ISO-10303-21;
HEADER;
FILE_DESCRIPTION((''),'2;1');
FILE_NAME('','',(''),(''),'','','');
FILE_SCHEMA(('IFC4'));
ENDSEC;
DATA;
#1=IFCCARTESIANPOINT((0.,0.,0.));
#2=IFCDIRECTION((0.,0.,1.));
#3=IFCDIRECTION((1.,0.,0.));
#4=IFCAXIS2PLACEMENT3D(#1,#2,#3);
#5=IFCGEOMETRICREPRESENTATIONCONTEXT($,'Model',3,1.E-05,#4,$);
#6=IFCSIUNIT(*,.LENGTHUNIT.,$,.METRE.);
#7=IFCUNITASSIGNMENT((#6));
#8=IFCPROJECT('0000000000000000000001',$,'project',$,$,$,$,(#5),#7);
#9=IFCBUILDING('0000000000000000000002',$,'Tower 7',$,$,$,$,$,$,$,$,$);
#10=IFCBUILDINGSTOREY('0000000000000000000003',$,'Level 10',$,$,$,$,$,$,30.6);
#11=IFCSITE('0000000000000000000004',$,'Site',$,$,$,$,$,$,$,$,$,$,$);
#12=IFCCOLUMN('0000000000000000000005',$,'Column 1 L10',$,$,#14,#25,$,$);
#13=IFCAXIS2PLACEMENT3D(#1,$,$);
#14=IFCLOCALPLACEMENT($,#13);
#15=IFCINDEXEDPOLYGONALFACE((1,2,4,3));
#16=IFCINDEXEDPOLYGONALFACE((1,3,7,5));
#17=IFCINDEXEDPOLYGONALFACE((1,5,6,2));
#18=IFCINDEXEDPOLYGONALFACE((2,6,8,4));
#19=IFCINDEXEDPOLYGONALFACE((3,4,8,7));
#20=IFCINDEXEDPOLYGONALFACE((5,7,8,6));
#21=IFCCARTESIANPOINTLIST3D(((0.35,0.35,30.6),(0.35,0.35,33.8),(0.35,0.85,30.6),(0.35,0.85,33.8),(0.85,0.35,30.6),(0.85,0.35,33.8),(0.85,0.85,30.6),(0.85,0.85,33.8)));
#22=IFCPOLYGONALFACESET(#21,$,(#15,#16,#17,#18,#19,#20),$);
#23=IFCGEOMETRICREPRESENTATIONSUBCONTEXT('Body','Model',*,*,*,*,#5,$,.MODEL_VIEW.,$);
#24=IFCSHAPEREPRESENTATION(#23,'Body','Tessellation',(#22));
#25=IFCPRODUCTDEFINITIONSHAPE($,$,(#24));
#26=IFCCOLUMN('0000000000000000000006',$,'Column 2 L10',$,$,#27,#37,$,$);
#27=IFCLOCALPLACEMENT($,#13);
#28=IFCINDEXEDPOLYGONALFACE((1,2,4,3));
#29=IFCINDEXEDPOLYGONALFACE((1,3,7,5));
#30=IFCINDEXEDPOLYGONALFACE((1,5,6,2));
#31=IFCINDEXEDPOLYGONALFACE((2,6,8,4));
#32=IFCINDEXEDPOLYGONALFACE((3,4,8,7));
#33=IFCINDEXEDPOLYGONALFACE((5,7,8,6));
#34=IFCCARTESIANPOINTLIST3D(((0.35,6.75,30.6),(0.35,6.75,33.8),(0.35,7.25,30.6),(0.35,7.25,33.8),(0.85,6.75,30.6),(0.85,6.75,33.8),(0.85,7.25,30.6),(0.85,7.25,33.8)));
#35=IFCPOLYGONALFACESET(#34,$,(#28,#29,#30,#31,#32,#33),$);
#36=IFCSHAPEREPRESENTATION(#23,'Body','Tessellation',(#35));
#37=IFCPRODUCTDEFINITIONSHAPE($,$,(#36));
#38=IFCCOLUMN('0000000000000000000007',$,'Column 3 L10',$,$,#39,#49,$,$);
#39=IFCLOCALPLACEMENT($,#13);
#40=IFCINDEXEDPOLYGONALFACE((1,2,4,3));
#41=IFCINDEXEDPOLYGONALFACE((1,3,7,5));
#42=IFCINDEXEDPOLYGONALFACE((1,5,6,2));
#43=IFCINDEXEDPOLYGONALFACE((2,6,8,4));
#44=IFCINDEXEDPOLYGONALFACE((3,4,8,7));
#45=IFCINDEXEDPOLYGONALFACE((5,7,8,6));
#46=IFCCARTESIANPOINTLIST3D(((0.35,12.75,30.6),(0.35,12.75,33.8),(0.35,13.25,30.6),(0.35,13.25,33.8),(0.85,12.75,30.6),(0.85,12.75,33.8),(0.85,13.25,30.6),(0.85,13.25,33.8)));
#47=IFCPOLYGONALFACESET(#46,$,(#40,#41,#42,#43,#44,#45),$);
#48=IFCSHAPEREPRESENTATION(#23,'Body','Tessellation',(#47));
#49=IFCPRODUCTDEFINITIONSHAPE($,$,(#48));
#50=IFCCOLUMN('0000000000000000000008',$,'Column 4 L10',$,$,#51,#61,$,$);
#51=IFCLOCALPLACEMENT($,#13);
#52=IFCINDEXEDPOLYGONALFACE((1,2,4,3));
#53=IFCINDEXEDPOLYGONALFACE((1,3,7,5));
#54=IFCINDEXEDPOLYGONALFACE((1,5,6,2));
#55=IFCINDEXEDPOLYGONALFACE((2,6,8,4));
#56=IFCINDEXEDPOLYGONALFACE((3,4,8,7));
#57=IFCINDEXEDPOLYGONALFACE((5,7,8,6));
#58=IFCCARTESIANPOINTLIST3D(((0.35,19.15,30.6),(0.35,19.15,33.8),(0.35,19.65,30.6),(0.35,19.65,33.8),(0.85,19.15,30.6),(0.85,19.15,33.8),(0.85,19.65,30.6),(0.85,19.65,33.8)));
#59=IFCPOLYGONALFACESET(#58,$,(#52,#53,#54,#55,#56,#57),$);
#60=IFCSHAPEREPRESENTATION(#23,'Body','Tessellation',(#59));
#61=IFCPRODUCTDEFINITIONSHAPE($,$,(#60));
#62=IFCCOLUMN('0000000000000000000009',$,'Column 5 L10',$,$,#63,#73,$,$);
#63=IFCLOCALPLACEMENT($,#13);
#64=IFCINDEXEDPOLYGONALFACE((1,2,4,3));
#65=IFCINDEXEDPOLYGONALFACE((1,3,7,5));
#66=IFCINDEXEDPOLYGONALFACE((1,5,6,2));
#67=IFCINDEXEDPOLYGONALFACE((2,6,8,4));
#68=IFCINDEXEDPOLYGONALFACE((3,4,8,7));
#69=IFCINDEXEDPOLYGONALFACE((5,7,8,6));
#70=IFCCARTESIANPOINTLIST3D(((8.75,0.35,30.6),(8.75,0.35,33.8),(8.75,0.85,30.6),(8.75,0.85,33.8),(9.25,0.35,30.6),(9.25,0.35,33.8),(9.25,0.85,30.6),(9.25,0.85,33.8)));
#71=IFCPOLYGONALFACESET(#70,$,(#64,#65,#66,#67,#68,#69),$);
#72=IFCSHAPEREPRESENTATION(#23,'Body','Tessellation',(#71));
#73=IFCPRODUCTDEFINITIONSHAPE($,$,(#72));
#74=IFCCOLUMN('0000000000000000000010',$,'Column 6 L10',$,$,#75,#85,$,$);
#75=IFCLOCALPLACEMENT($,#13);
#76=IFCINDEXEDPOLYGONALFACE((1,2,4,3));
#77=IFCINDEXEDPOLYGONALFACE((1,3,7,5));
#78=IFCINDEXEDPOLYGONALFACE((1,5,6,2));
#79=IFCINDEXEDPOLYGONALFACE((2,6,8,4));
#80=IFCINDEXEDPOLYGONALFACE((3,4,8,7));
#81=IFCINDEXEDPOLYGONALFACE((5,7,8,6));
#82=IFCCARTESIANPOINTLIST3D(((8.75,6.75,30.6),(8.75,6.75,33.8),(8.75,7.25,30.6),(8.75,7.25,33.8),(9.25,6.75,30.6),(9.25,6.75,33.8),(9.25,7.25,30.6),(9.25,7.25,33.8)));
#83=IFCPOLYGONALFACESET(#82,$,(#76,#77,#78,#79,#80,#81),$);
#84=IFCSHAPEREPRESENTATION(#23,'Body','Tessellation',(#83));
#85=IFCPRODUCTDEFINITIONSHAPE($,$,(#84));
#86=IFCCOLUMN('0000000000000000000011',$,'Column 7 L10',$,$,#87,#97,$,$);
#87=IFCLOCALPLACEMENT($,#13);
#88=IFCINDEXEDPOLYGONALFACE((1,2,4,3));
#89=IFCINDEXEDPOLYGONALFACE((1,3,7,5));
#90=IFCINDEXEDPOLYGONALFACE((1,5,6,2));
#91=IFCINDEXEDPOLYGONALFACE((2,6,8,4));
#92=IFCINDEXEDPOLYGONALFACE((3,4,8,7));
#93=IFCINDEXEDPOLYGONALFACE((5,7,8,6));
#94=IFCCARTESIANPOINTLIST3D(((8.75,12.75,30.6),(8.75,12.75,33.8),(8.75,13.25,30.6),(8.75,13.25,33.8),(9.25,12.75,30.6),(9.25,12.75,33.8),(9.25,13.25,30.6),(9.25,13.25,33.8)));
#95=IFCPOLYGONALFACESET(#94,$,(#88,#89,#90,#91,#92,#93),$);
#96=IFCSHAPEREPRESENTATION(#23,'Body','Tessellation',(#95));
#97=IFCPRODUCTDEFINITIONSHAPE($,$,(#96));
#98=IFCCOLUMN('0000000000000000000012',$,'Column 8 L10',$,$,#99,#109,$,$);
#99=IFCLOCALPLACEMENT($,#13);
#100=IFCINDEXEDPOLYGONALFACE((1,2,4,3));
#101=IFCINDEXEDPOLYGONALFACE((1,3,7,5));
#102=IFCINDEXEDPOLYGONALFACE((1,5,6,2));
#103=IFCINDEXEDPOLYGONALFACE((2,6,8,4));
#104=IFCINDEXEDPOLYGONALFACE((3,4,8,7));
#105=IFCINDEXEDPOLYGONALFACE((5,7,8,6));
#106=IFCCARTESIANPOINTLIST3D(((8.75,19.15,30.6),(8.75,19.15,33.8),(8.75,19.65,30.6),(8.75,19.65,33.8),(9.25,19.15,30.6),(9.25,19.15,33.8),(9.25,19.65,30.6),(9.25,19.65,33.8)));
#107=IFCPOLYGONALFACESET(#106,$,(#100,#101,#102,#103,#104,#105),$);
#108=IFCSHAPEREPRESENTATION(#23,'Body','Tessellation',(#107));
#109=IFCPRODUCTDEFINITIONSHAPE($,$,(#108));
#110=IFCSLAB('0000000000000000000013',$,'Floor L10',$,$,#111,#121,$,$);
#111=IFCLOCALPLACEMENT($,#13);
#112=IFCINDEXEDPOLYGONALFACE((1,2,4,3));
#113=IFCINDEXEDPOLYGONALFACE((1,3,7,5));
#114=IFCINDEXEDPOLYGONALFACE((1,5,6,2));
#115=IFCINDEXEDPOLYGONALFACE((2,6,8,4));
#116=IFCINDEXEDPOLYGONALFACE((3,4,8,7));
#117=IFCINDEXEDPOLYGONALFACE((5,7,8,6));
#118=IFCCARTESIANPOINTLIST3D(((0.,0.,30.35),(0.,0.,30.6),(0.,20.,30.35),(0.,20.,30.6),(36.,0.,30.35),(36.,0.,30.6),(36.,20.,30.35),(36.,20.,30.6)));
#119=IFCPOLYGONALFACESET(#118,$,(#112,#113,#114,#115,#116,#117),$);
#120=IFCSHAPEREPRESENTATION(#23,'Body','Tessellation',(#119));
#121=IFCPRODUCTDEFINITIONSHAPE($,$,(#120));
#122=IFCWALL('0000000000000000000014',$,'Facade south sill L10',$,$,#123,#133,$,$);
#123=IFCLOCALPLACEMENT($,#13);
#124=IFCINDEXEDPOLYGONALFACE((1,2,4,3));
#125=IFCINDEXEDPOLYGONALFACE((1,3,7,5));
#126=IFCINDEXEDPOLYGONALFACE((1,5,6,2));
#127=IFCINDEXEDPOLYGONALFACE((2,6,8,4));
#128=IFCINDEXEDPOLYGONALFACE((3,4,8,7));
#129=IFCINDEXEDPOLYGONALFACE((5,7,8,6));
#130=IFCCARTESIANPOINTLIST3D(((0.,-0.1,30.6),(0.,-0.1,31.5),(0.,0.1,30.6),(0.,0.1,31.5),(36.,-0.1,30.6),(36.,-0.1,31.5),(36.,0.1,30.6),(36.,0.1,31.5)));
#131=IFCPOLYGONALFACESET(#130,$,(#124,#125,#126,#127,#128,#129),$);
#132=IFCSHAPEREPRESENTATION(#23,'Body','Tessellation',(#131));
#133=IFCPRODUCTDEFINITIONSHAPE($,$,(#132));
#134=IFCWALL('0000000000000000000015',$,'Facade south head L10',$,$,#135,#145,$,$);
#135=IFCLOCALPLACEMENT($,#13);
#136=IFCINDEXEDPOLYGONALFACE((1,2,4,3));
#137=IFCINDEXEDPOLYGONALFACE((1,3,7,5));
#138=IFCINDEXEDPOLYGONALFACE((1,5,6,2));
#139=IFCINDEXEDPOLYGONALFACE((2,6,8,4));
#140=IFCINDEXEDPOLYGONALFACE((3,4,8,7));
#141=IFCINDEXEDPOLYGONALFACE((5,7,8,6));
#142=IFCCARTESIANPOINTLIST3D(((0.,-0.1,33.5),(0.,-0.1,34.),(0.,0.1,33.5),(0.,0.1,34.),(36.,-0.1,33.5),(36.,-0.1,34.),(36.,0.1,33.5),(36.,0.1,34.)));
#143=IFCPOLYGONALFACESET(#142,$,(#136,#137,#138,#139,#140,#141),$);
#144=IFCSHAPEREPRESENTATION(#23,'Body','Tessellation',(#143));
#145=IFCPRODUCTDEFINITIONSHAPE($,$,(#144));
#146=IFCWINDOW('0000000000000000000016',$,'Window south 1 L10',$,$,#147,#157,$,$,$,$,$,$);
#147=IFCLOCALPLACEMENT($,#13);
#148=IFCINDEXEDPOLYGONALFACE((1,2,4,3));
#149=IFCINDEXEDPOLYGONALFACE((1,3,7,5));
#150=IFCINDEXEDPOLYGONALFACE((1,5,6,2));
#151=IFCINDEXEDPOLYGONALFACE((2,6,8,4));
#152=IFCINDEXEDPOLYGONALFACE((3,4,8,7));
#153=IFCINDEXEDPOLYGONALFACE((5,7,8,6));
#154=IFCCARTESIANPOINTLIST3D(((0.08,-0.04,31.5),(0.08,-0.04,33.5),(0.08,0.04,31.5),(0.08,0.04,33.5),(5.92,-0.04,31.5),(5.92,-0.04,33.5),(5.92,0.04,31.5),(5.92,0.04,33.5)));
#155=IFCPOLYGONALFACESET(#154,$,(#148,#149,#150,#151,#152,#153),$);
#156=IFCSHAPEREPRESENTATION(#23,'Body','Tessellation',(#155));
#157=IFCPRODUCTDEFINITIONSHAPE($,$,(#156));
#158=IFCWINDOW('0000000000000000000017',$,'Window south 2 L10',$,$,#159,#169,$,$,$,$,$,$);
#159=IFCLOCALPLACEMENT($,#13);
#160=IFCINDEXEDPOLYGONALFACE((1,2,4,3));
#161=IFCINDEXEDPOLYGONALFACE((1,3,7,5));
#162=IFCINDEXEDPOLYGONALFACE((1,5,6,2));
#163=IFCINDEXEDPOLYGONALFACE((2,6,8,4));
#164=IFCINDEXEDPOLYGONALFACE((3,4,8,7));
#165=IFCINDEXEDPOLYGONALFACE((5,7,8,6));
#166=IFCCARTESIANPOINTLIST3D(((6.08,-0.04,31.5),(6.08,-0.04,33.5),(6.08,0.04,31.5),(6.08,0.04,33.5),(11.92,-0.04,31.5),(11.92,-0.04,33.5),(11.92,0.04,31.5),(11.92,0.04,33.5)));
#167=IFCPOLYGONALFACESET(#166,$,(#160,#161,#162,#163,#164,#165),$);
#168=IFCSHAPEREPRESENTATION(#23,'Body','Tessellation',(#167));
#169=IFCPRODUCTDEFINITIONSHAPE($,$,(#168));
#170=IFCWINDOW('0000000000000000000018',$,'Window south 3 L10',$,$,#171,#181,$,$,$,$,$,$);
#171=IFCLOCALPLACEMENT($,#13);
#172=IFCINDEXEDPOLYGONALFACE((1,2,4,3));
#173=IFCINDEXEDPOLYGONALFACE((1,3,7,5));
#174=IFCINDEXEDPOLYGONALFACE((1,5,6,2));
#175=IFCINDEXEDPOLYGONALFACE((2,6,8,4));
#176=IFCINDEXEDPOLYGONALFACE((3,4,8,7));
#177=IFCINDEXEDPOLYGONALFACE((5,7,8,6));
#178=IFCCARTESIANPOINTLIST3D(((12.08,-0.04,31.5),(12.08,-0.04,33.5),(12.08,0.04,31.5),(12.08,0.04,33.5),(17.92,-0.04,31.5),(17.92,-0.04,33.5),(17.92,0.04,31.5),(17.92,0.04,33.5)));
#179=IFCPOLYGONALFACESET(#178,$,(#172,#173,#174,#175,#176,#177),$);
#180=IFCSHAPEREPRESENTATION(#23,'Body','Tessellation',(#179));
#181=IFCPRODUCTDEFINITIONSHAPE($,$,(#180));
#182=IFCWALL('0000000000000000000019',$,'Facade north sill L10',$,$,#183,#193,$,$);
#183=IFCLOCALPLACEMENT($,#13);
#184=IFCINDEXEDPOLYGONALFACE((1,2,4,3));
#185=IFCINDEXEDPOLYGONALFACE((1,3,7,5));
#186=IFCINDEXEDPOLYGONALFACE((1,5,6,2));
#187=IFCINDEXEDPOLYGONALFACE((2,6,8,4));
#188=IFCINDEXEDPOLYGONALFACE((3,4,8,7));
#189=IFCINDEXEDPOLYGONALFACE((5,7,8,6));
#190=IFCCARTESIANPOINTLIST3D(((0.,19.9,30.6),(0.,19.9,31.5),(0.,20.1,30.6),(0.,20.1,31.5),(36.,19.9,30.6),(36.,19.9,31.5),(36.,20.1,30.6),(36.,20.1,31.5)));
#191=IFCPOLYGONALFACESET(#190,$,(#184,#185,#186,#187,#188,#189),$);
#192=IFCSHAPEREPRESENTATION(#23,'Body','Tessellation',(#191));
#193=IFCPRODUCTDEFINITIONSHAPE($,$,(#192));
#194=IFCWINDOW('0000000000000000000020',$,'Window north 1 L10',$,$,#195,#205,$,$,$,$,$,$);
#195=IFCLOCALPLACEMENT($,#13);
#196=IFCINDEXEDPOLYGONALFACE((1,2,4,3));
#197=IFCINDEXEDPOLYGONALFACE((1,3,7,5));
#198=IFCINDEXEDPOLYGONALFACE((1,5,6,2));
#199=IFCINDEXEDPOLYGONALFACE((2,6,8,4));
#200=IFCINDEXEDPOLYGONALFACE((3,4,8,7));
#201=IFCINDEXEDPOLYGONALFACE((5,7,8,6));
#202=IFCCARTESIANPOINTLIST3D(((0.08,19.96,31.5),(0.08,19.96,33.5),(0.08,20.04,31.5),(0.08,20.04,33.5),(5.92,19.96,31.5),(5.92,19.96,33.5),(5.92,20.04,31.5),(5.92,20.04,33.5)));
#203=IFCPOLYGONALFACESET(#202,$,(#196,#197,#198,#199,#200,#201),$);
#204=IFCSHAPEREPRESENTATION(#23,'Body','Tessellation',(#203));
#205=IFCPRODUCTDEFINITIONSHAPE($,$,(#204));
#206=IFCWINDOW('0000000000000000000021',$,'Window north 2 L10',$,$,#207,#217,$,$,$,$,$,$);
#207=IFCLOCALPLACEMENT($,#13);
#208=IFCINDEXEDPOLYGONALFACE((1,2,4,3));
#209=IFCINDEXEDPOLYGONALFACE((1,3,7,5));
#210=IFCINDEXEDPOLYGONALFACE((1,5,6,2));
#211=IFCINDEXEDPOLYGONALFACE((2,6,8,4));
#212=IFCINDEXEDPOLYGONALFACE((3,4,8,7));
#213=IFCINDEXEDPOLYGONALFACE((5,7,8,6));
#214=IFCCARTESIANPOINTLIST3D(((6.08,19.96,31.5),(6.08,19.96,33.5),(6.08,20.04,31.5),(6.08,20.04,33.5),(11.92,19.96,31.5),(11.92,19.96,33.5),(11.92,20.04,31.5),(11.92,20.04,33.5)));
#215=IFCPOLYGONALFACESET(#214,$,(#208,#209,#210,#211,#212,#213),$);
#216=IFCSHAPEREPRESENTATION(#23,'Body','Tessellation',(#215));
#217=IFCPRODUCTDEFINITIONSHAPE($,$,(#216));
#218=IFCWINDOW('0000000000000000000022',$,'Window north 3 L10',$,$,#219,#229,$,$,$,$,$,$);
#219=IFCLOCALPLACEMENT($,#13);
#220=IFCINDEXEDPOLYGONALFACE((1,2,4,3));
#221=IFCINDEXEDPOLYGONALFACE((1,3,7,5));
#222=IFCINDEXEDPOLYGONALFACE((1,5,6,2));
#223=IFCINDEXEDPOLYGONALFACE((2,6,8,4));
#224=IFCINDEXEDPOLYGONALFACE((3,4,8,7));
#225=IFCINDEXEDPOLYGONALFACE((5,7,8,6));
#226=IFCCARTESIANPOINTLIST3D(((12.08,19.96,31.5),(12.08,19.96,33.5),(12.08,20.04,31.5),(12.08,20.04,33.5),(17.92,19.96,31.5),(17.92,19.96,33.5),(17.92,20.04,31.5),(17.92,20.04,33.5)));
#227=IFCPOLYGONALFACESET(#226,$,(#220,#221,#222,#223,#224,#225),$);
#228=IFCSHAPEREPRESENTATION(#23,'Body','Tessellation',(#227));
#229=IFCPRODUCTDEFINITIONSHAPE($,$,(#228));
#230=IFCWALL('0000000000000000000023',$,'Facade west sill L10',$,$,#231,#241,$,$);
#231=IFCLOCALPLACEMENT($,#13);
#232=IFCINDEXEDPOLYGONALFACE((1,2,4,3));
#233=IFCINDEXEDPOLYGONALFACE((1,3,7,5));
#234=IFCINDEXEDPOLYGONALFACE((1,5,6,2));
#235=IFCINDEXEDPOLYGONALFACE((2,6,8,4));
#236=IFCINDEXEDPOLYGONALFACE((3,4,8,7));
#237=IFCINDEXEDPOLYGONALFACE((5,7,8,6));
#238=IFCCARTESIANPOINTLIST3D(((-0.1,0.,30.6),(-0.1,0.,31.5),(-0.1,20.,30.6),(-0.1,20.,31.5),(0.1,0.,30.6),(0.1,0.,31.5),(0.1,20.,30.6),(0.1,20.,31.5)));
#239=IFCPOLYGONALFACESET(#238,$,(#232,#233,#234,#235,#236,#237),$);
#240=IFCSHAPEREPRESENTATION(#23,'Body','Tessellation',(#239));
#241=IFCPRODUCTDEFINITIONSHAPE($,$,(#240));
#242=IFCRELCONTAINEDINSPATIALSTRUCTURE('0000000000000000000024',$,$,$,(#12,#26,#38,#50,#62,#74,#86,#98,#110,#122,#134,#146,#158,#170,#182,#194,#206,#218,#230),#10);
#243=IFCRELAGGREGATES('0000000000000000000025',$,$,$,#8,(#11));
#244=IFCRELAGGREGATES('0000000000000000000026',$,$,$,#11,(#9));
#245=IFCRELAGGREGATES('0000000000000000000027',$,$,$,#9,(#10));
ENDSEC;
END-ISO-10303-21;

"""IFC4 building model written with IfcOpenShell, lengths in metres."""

from ifc_helpers import new_model, si_unit, frame, origin, origin_with_axes, origin_2d, place, context, subcontext, project, spatial, rectangle, extrude, element, save


model = new_model("IFC4")

# Units and contexts
model_context = context("Model", 3, precision=1e-05, world=origin_with_axes())
body_context = subcontext(model_context, "Body", "Model", "MODEL_VIEW")
ifc_project = project(units=[si_unit("LENGTHUNIT", "METRE")], contexts=[model_context])

# Site, building, storey
site = spatial("IfcSite", under=ifc_project, Name="Site")
building = spatial("IfcBuilding", under=site, Name="Tower 7")
storey = spatial("IfcBuildingStorey", under=building, Name="Level 10", Elevation=30.6)

# Columns
for number, where, z_axis, x_axis, name in (
    (1, (0.6, 0.6, 30.6), (0.0, 0.0, 1.0), (1.0, 0.0, 0.0), "Column 1 L10"),
    (2, (0.6, 7.0, 30.6), (0.0, 0.0, 1.0), (1.0, 0.0, 0.0), "Column 2 L10"),
    (3, (0.6, 13.0, 30.6), (0.0, 0.0, 1.0), (1.0, 0.0, 0.0), "Column 3 L10"),
    (4, (0.6, 19.4, 30.6), (0.0, 0.0, 1.0), (1.0, 0.0, 0.0), "Column 4 L10"),
    (5, (9.0, 0.6, 30.6), (0.0, 0.0, 1.0), (1.0, 0.0, 0.0), "Column 5 L10"),
    (6, (9.0, 7.0, 30.6), (0.0, 0.0, 1.0), (1.0, 0.0, 0.0), "Column 6 L10"),
    (7, (9.0, 13.0, 30.6), (0.0, 0.0, 1.0), (1.0, 0.0, 0.0), "Column 7 L10"),
    (8, (9.0, 19.4, 30.6), (0.0, 0.0, 1.0), (1.0, 0.0, 0.0), "Column 8 L10"),
):
    element("IfcColumn", number, at=place(None, frame(where, z_axis=z_axis, x_axis=x_axis)), inside=storey, Name=name, context=body_context, shape_type="SweptSolid", body=[
        extrude(rectangle(XDim=0.5, YDim=0.5, at=origin_2d()), origin(), (0.0, 0.0, 1.0), 3.2),
    ])

# Slab
slab_placement = place(None, frame((18.0, 10.0, 30.35), z_axis=(0.0, 0.0, 1.0), x_axis=(1.0, 0.0, 0.0)))
element("IfcSlab", 9, at=slab_placement, inside=storey, Name="Floor L10", context=body_context, shape_type="SweptSolid", body=[
    extrude(rectangle(XDim=36.0, YDim=20.0, at=origin_2d()), origin(), (0.0, 0.0, 1.0), 0.25),
])

# Walls
wall_1_placement = place(None, frame((18.0, 0.0, 30.6), z_axis=(0.0, 0.0, 1.0), x_axis=(1.0, 0.0, 0.0)))
element("IfcWall", 10, at=wall_1_placement, inside=storey, Name="Facade south sill L10", context=body_context, shape_type="SweptSolid", body=[
    extrude(rectangle(XDim=36.0, YDim=0.2, at=origin_2d()), origin(), (0.0, 0.0, 1.0), 0.9),
])
wall_2_placement = place(None, frame((18.0, 0.0, 33.5), z_axis=(0.0, 0.0, 1.0), x_axis=(1.0, 0.0, 0.0)))
element("IfcWall", 11, at=wall_2_placement, inside=storey, Name="Facade south head L10", context=body_context, shape_type="SweptSolid", body=[
    extrude(rectangle(XDim=36.0, YDim=0.2, at=origin_2d()), origin(), (0.0, 0.0, 1.0), 0.5),
])

# Windows
for number, where, z_axis, x_axis, name in (
    (12, (3.0, 0.0, 31.5), (0.0, 0.0, 1.0), (1.0, 0.0, 0.0), "Window south 1 L10"),
    (13, (9.0, 0.0, 31.5), (0.0, 0.0, 1.0), (1.0, 0.0, 0.0), "Window south 2 L10"),
):
    element("IfcWindow", number, at=place(None, frame(where, z_axis=z_axis, x_axis=x_axis)), inside=storey, Name=name, context=body_context, shape_type="SweptSolid", body=[
        extrude(rectangle(XDim=5.84, YDim=0.08, at=origin_2d()), origin(), (0.0, 0.0, 1.0), 2.0),
    ])
window_1_placement = place(None, frame((15.0, 0.0, 31.5), z_axis=(0.0, 0.0, 1.0), x_axis=(1.0, 0.0, 0.0)))
element("IfcWindow", 14, at=window_1_placement, inside=storey, Name="Window south 3 L10", context=body_context, shape_type="SweptSolid", body=[
    extrude(rectangle(XDim=5.84, YDim=0.08, at=origin_2d()), origin(), (0.0, 0.0, 1.0), 2.0),
])

# Wall
wall_3_placement = place(None, frame((18.0, 20.0, 30.6), z_axis=(0.0, 0.0, 1.0), x_axis=(1.0, 0.0, 0.0)))
element("IfcWall", 15, at=wall_3_placement, inside=storey, Name="Facade north sill L10", context=body_context, shape_type="SweptSolid", body=[
    extrude(rectangle(XDim=36.0, YDim=0.2, at=origin_2d()), origin(), (0.0, 0.0, 1.0), 0.9),
])

# Windows
for number, where, z_axis, x_axis, name in (
    (16, (3.0, 20.0, 31.5), (0.0, 0.0, 1.0), (1.0, 0.0, 0.0), "Window north 1 L10"),
    (17, (9.0, 20.0, 31.5), (0.0, 0.0, 1.0), (1.0, 0.0, 0.0), "Window north 2 L10"),
):
    element("IfcWindow", number, at=place(None, frame(where, z_axis=z_axis, x_axis=x_axis)), inside=storey, Name=name, context=body_context, shape_type="SweptSolid", body=[
        extrude(rectangle(XDim=5.84, YDim=0.08, at=origin_2d()), origin(), (0.0, 0.0, 1.0), 2.0),
    ])
window_2_placement = place(None, frame((15.0, 20.0, 31.5), z_axis=(0.0, 0.0, 1.0), x_axis=(1.0, 0.0, 0.0)))
element("IfcWindow", 18, at=window_2_placement, inside=storey, Name="Window north 3 L10", context=body_context, shape_type="SweptSolid", body=[
    extrude(rectangle(XDim=5.84, YDim=0.08, at=origin_2d()), origin(), (0.0, 0.0, 1.0), 2.0),
])

# Wall
wall_4_placement = place(None, frame((0.0, 10.0, 30.6), z_axis=(0.0, 0.0, 1.0), x_axis=(1.0, 0.0, 0.0)))
element("IfcWall", 19, at=wall_4_placement, inside=storey, Name="Facade west sill L10", context=body_context, shape_type="SweptSolid", body=[
    extrude(rectangle(XDim=0.2, YDim=20.0, at=origin_2d()), origin(), (0.0, 0.0, 1.0), 0.9),
])

save(model, "model.ifc")
